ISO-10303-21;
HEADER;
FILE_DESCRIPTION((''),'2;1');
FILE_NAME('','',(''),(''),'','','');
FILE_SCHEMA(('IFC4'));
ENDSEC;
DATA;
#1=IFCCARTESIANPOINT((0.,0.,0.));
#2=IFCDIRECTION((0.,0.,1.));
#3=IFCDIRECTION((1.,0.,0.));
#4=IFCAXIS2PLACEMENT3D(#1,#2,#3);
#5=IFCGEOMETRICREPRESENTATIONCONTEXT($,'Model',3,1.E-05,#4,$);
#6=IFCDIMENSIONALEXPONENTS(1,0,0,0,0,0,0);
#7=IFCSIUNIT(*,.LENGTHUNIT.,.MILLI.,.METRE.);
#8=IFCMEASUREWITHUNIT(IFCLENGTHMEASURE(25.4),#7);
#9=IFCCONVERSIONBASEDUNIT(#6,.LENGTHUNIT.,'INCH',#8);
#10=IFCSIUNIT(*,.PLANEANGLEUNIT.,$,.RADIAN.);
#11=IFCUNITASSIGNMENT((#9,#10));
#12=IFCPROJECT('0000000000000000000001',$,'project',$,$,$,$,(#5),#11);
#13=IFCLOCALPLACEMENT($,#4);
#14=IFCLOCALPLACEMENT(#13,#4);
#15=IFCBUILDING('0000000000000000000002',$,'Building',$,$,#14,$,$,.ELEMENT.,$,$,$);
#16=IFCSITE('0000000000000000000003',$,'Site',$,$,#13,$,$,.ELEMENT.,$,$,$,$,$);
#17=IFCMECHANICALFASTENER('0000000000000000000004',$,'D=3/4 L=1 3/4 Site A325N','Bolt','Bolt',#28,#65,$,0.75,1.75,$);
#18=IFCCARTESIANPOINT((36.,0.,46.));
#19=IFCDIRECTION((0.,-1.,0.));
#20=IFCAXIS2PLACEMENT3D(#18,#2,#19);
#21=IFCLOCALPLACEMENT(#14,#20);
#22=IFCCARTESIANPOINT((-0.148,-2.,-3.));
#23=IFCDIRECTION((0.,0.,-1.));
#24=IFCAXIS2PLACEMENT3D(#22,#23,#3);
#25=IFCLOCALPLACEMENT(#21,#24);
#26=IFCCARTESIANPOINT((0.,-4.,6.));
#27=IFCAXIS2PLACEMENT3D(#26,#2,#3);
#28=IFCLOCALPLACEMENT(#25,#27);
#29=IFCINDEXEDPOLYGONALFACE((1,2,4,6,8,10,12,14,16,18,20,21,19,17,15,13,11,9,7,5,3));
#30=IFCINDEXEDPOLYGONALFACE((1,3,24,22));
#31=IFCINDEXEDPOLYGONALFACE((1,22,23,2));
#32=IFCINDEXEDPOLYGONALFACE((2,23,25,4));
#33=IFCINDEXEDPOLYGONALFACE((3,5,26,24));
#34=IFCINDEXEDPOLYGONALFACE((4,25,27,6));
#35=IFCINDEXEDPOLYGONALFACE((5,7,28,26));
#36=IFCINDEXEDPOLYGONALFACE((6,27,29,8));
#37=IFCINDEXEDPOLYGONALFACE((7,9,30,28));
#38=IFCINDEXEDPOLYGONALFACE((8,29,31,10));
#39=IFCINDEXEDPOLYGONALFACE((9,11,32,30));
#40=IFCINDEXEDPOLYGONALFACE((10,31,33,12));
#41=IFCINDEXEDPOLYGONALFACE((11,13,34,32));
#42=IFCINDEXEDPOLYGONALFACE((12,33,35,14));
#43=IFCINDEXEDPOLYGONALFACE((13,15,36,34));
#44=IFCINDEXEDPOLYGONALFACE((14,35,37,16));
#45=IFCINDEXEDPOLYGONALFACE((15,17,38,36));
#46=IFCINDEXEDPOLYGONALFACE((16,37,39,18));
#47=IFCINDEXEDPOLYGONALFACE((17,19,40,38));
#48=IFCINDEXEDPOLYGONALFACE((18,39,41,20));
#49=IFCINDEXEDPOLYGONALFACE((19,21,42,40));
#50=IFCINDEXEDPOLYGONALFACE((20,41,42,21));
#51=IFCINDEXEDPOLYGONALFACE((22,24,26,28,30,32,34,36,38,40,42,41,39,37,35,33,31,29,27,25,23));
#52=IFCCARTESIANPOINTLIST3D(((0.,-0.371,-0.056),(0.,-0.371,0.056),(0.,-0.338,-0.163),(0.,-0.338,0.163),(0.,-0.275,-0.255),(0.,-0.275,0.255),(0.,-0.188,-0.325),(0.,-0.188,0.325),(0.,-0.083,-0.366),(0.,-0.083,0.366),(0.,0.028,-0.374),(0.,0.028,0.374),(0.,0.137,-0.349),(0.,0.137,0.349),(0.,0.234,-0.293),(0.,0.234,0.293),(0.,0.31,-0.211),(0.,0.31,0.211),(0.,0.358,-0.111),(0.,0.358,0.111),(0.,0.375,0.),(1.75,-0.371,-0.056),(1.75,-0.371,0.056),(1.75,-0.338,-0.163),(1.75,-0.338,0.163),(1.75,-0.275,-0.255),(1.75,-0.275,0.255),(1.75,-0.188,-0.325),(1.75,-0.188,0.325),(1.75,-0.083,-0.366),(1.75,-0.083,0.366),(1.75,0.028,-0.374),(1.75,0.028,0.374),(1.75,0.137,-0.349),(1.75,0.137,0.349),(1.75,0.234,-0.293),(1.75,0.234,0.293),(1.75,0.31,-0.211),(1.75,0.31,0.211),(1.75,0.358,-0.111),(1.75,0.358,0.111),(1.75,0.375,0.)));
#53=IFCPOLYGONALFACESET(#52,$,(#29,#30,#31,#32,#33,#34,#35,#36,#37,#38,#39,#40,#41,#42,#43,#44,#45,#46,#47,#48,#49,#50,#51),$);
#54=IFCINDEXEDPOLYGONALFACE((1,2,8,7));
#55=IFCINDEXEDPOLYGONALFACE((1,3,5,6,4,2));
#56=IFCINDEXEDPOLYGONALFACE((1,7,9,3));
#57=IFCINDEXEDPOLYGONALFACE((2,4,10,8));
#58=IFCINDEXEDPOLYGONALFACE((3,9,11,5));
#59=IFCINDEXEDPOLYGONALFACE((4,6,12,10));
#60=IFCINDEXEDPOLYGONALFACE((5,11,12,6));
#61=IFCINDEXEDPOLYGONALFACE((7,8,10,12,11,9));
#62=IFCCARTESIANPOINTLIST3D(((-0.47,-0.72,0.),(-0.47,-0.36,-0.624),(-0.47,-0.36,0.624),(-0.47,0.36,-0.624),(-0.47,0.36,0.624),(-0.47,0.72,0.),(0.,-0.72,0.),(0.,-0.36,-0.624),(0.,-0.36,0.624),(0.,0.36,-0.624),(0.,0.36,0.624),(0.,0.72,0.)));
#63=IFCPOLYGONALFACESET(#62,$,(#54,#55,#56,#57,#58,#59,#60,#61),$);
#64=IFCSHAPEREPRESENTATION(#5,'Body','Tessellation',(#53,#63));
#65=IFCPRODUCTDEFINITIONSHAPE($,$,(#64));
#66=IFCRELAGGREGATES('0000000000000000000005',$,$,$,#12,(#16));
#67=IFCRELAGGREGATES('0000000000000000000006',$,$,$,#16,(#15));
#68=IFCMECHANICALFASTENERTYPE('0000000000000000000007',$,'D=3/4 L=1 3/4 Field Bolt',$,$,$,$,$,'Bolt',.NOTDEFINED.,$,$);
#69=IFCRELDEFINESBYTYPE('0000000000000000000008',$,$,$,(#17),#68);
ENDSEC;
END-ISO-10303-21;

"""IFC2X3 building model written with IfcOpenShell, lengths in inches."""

from ifc_helpers import new_model, entity, si_unit, converted_unit, frame, origin_with_axes, origin_2d_with_axis, place, context, project, spatial, polyline, circle, outline, extrude, source, transform, mapped, type_object, type_shapes, element, save


model = new_model("IFC2X3")

# Units and contexts
model_context = context("Model", 3, precision=1e-05, world=origin_with_axes())
ifc_project = project(units=[converted_unit("LENGTHUNIT", "INCH", entity("IfcLengthMeasure", 25.4), si_unit("LENGTHUNIT", "METRE", prefix="MILLI"), dimensions=[1, 0, 0, 0, 0, 0, 0]), si_unit("PLANEANGLEUNIT", "RADIAN")], contexts=[model_context])

# Site, building
site_placement = place(None, origin_with_axes())
site = spatial("IfcSite", under=ifc_project, at=site_placement, Name="Site", CompositionType="ELEMENT")
building_placement = place(site_placement, origin_with_axes())
building = spatial("IfcBuilding", under=site, at=building_placement, Name="Building", CompositionType="ELEMENT")

# Mechanical fastener
mechanical_fastener_type_1 = type_object("IfcMechanicalFastenerType", Name="D=3/4 L=1 3/4 Field Bolt", ElementType="Bolt")
shared_shape_1 = source(origin_with_axes(), model_context, "Body", "SweptSolid", [
    extrude(circle(Radius=0.375, at=origin_2d_with_axis()), frame((0.0, 0.0, 0.0), z_axis=(1.0, 0.0, 0.0), x_axis=(0.0, 1.0, 0.0)), (0.0, 0.0, 1.0), 1.75),
    extrude(outline(polyline([(-0.72, 0.0), (-0.36, 0.624), (0.36, 0.624), (0.72, 0.0), (0.36, -0.624), (-0.36, -0.624), (-0.72, 0.0)])), frame((0.0, 0.0, 0.0), z_axis=(1.0, 0.0, 0.0), x_axis=(0.0, 1.0, 0.0)), (0.0, 0.0, -1.0), 0.47),
])
type_shapes(mechanical_fastener_type_1, [shared_shape_1])
placement_1 = place(building_placement, frame((36.0, 0.0, 46.0), z_axis=(0.0, 0.0, 1.0), x_axis=(0.0, -1.0, 0.0)))
placement_2 = place(placement_1, frame((-0.148, -2.0, -3.0), z_axis=(0.0, 0.0, -1.0), x_axis=(1.0, 0.0, 0.0)))
for number, where, z_axis, x_axis, name in (
    (1, (0.0, -4.0, 6.0), (0.0, 0.0, 1.0), (1.0, 0.0, 0.0), "D=3/4 L=1 3/4 Site A325N"),
):
    element("IfcMechanicalFastener", number, at=place(placement_2, frame(where, z_axis=z_axis, x_axis=x_axis)), type_object=mechanical_fastener_type_1, Name=name, Description="Bolt", ObjectType="Bolt", NominalDiameter=0.75, NominalLength=1.75, context=model_context, shape_type="MappedRepresentation", body=[
        mapped(shared_shape_1, transform((0.0, 0.0, 0.0), scale=1.0)),
    ])

save(model, "model.ifc")
